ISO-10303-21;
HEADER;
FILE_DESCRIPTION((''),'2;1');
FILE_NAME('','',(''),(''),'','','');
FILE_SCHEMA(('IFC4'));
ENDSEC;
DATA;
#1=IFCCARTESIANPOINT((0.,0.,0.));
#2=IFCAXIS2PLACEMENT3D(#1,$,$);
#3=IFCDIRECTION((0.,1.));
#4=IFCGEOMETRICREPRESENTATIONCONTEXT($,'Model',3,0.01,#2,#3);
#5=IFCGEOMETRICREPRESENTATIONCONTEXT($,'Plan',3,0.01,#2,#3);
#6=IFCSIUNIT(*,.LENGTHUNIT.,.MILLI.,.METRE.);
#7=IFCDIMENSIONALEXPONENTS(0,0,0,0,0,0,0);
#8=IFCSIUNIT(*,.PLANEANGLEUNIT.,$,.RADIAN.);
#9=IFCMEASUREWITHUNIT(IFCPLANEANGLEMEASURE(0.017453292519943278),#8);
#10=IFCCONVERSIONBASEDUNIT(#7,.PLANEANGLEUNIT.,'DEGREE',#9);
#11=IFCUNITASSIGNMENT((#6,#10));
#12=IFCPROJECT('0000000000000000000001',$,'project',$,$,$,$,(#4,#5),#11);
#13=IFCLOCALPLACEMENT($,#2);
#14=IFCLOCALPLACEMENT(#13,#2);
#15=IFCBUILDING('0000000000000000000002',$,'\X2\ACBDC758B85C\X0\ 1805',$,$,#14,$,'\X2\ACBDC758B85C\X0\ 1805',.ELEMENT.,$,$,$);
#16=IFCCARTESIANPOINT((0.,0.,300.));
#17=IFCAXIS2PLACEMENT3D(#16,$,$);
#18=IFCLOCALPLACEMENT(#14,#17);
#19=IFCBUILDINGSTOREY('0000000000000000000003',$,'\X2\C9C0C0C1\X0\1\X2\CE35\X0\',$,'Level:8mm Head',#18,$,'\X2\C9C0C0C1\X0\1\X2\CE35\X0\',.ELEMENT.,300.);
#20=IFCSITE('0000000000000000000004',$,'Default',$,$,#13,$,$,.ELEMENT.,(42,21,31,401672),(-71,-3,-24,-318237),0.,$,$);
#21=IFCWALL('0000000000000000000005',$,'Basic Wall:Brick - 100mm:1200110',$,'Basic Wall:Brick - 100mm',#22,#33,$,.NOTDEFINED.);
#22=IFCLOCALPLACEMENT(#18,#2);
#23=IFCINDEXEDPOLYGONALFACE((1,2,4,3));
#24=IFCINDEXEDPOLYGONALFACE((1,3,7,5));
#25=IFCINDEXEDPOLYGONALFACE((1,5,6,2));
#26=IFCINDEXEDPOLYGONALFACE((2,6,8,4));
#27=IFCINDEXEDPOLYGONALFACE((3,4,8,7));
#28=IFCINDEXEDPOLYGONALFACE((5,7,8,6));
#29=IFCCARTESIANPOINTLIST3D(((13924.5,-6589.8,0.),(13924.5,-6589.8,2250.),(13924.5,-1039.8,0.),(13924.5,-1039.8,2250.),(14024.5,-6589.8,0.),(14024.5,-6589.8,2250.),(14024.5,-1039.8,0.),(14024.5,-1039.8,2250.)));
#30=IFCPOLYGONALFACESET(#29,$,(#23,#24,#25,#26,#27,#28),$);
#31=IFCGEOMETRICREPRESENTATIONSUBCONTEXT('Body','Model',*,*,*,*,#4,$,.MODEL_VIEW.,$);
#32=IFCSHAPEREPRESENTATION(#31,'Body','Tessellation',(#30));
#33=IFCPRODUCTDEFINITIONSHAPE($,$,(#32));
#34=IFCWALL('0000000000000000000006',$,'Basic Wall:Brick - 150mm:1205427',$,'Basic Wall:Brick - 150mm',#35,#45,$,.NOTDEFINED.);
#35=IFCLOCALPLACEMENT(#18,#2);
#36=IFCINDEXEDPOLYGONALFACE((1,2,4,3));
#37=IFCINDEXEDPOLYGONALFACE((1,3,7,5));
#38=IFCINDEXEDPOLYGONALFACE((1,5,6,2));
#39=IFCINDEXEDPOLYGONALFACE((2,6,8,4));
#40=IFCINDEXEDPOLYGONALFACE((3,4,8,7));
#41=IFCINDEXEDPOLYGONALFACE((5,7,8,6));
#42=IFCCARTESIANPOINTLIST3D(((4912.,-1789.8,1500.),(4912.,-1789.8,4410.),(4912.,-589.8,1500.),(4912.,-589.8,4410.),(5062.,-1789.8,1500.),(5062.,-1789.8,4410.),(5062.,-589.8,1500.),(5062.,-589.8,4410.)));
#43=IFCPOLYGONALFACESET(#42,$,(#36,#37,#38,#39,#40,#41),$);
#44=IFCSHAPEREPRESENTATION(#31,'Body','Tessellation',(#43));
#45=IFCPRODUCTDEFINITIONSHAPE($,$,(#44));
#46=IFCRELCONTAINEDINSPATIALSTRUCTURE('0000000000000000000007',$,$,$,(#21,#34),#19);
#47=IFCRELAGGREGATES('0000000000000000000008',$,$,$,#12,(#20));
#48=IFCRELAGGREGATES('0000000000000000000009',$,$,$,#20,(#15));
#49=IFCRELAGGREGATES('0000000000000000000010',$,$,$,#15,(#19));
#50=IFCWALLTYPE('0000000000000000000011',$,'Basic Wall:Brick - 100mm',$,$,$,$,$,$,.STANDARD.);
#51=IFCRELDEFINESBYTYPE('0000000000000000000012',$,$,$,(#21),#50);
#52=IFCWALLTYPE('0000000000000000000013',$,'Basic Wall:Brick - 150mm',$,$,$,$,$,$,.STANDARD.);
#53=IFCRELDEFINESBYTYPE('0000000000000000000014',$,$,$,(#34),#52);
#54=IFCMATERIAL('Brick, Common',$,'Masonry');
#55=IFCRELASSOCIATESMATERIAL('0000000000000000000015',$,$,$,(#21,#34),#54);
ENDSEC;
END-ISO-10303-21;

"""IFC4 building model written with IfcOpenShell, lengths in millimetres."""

from ifc_helpers import new_model, entity, si_unit, converted_unit, direction, frame, origin, place, context, subcontext, project, spatial, indexed_curve, outline, extrude, material, type_object, element, save


model = new_model("IFC4")

# Units and contexts
model_context = context("Model", 3, precision=0.01, world=origin(), true_north=direction((0.0, 1.0)))
plan_context = context("Plan", 3, precision=0.01, world=origin(), true_north=direction((0.0, 1.0)))
body_context = subcontext(model_context, "Body", "Model", "MODEL_VIEW")
ifc_project = project(units=[si_unit("LENGTHUNIT", "METRE", prefix="MILLI"), converted_unit("PLANEANGLEUNIT", "DEGREE", entity("IfcPlaneAngleMeasure", 0.017453292519943278), si_unit("PLANEANGLEUNIT", "RADIAN"), dimensions=[0, 0, 0, 0, 0, 0, 0])], contexts=[model_context, plan_context])

# Site, building, storey
site_placement = place(None, origin())
site = spatial("IfcSite", under=ifc_project, at=site_placement, Name="Default", CompositionType="ELEMENT", RefLatitude=(42, 21, 31, 401672), RefLongitude=(-71, -3, -24, -318237), RefElevation=0.0)
building_placement = place(site_placement, origin())
building = spatial("IfcBuilding", under=site, at=building_placement, Name="경의로 1805", LongName="경의로 1805", CompositionType="ELEMENT")
storey_placement = place(building_placement, frame((0.0, 0.0, 300.0)))
storey = spatial("IfcBuildingStorey", under=building, at=storey_placement, Name="지상1층", ObjectType="Level:8mm Head", LongName="지상1층", CompositionType="ELEMENT", Elevation=300.0)

# Walls
ifc_material_1 = material(Name="Brick, Common", Category="Masonry")
wall_type_1 = type_object("IfcWallType", Name="Basic Wall:Brick - 100mm", PredefinedType="STANDARD")
wall_1_placement = place(storey_placement, frame((13974.5, -1039.8, 0.0), z_axis=(0.0, 0.0, 1.0), x_axis=(0.0, -1.0, 0.0)))
element("IfcWall", 1, at=wall_1_placement, inside=storey, type_object=wall_type_1, material=ifc_material_1, Name="Basic Wall:Brick - 100mm:1200110", ObjectType="Basic Wall:Brick - 100mm", PredefinedType="NOTDEFINED", context=body_context, shape_type="SweptSolid", body=[
    extrude(outline(indexed_curve([(5550.0, 50.0), (0.0, 50.0), (0.0, -50.0), (5550.0, -50.0), (5550.0, 50.0)], self_intersect=False)), origin(), (0.0, 0.0, 1.0), 2250.0),
])
wall_type_2 = type_object("IfcWallType", Name="Basic Wall:Brick - 150mm", PredefinedType="STANDARD")
wall_2_placement = place(storey_placement, frame((4987.0, -1789.8, 1500.0), z_axis=(0.0, 0.0, 1.0), x_axis=(0.0, 1.0, 0.0)))
element("IfcWall", 2, at=wall_2_placement, inside=storey, type_object=wall_type_2, material=ifc_material_1, Name="Basic Wall:Brick - 150mm:1205427", ObjectType="Basic Wall:Brick - 150mm", PredefinedType="NOTDEFINED", context=body_context, shape_type="SweptSolid", body=[
    extrude(outline(indexed_curve([(1200.0, 75.0), (0.0, 75.0), (0.0, -75.0), (1200.0, -75.0), (1200.0, 75.0)], self_intersect=False)), origin(), (0.0, 0.0, 1.0), 2910.0),
])

save(model, "model.ifc")
